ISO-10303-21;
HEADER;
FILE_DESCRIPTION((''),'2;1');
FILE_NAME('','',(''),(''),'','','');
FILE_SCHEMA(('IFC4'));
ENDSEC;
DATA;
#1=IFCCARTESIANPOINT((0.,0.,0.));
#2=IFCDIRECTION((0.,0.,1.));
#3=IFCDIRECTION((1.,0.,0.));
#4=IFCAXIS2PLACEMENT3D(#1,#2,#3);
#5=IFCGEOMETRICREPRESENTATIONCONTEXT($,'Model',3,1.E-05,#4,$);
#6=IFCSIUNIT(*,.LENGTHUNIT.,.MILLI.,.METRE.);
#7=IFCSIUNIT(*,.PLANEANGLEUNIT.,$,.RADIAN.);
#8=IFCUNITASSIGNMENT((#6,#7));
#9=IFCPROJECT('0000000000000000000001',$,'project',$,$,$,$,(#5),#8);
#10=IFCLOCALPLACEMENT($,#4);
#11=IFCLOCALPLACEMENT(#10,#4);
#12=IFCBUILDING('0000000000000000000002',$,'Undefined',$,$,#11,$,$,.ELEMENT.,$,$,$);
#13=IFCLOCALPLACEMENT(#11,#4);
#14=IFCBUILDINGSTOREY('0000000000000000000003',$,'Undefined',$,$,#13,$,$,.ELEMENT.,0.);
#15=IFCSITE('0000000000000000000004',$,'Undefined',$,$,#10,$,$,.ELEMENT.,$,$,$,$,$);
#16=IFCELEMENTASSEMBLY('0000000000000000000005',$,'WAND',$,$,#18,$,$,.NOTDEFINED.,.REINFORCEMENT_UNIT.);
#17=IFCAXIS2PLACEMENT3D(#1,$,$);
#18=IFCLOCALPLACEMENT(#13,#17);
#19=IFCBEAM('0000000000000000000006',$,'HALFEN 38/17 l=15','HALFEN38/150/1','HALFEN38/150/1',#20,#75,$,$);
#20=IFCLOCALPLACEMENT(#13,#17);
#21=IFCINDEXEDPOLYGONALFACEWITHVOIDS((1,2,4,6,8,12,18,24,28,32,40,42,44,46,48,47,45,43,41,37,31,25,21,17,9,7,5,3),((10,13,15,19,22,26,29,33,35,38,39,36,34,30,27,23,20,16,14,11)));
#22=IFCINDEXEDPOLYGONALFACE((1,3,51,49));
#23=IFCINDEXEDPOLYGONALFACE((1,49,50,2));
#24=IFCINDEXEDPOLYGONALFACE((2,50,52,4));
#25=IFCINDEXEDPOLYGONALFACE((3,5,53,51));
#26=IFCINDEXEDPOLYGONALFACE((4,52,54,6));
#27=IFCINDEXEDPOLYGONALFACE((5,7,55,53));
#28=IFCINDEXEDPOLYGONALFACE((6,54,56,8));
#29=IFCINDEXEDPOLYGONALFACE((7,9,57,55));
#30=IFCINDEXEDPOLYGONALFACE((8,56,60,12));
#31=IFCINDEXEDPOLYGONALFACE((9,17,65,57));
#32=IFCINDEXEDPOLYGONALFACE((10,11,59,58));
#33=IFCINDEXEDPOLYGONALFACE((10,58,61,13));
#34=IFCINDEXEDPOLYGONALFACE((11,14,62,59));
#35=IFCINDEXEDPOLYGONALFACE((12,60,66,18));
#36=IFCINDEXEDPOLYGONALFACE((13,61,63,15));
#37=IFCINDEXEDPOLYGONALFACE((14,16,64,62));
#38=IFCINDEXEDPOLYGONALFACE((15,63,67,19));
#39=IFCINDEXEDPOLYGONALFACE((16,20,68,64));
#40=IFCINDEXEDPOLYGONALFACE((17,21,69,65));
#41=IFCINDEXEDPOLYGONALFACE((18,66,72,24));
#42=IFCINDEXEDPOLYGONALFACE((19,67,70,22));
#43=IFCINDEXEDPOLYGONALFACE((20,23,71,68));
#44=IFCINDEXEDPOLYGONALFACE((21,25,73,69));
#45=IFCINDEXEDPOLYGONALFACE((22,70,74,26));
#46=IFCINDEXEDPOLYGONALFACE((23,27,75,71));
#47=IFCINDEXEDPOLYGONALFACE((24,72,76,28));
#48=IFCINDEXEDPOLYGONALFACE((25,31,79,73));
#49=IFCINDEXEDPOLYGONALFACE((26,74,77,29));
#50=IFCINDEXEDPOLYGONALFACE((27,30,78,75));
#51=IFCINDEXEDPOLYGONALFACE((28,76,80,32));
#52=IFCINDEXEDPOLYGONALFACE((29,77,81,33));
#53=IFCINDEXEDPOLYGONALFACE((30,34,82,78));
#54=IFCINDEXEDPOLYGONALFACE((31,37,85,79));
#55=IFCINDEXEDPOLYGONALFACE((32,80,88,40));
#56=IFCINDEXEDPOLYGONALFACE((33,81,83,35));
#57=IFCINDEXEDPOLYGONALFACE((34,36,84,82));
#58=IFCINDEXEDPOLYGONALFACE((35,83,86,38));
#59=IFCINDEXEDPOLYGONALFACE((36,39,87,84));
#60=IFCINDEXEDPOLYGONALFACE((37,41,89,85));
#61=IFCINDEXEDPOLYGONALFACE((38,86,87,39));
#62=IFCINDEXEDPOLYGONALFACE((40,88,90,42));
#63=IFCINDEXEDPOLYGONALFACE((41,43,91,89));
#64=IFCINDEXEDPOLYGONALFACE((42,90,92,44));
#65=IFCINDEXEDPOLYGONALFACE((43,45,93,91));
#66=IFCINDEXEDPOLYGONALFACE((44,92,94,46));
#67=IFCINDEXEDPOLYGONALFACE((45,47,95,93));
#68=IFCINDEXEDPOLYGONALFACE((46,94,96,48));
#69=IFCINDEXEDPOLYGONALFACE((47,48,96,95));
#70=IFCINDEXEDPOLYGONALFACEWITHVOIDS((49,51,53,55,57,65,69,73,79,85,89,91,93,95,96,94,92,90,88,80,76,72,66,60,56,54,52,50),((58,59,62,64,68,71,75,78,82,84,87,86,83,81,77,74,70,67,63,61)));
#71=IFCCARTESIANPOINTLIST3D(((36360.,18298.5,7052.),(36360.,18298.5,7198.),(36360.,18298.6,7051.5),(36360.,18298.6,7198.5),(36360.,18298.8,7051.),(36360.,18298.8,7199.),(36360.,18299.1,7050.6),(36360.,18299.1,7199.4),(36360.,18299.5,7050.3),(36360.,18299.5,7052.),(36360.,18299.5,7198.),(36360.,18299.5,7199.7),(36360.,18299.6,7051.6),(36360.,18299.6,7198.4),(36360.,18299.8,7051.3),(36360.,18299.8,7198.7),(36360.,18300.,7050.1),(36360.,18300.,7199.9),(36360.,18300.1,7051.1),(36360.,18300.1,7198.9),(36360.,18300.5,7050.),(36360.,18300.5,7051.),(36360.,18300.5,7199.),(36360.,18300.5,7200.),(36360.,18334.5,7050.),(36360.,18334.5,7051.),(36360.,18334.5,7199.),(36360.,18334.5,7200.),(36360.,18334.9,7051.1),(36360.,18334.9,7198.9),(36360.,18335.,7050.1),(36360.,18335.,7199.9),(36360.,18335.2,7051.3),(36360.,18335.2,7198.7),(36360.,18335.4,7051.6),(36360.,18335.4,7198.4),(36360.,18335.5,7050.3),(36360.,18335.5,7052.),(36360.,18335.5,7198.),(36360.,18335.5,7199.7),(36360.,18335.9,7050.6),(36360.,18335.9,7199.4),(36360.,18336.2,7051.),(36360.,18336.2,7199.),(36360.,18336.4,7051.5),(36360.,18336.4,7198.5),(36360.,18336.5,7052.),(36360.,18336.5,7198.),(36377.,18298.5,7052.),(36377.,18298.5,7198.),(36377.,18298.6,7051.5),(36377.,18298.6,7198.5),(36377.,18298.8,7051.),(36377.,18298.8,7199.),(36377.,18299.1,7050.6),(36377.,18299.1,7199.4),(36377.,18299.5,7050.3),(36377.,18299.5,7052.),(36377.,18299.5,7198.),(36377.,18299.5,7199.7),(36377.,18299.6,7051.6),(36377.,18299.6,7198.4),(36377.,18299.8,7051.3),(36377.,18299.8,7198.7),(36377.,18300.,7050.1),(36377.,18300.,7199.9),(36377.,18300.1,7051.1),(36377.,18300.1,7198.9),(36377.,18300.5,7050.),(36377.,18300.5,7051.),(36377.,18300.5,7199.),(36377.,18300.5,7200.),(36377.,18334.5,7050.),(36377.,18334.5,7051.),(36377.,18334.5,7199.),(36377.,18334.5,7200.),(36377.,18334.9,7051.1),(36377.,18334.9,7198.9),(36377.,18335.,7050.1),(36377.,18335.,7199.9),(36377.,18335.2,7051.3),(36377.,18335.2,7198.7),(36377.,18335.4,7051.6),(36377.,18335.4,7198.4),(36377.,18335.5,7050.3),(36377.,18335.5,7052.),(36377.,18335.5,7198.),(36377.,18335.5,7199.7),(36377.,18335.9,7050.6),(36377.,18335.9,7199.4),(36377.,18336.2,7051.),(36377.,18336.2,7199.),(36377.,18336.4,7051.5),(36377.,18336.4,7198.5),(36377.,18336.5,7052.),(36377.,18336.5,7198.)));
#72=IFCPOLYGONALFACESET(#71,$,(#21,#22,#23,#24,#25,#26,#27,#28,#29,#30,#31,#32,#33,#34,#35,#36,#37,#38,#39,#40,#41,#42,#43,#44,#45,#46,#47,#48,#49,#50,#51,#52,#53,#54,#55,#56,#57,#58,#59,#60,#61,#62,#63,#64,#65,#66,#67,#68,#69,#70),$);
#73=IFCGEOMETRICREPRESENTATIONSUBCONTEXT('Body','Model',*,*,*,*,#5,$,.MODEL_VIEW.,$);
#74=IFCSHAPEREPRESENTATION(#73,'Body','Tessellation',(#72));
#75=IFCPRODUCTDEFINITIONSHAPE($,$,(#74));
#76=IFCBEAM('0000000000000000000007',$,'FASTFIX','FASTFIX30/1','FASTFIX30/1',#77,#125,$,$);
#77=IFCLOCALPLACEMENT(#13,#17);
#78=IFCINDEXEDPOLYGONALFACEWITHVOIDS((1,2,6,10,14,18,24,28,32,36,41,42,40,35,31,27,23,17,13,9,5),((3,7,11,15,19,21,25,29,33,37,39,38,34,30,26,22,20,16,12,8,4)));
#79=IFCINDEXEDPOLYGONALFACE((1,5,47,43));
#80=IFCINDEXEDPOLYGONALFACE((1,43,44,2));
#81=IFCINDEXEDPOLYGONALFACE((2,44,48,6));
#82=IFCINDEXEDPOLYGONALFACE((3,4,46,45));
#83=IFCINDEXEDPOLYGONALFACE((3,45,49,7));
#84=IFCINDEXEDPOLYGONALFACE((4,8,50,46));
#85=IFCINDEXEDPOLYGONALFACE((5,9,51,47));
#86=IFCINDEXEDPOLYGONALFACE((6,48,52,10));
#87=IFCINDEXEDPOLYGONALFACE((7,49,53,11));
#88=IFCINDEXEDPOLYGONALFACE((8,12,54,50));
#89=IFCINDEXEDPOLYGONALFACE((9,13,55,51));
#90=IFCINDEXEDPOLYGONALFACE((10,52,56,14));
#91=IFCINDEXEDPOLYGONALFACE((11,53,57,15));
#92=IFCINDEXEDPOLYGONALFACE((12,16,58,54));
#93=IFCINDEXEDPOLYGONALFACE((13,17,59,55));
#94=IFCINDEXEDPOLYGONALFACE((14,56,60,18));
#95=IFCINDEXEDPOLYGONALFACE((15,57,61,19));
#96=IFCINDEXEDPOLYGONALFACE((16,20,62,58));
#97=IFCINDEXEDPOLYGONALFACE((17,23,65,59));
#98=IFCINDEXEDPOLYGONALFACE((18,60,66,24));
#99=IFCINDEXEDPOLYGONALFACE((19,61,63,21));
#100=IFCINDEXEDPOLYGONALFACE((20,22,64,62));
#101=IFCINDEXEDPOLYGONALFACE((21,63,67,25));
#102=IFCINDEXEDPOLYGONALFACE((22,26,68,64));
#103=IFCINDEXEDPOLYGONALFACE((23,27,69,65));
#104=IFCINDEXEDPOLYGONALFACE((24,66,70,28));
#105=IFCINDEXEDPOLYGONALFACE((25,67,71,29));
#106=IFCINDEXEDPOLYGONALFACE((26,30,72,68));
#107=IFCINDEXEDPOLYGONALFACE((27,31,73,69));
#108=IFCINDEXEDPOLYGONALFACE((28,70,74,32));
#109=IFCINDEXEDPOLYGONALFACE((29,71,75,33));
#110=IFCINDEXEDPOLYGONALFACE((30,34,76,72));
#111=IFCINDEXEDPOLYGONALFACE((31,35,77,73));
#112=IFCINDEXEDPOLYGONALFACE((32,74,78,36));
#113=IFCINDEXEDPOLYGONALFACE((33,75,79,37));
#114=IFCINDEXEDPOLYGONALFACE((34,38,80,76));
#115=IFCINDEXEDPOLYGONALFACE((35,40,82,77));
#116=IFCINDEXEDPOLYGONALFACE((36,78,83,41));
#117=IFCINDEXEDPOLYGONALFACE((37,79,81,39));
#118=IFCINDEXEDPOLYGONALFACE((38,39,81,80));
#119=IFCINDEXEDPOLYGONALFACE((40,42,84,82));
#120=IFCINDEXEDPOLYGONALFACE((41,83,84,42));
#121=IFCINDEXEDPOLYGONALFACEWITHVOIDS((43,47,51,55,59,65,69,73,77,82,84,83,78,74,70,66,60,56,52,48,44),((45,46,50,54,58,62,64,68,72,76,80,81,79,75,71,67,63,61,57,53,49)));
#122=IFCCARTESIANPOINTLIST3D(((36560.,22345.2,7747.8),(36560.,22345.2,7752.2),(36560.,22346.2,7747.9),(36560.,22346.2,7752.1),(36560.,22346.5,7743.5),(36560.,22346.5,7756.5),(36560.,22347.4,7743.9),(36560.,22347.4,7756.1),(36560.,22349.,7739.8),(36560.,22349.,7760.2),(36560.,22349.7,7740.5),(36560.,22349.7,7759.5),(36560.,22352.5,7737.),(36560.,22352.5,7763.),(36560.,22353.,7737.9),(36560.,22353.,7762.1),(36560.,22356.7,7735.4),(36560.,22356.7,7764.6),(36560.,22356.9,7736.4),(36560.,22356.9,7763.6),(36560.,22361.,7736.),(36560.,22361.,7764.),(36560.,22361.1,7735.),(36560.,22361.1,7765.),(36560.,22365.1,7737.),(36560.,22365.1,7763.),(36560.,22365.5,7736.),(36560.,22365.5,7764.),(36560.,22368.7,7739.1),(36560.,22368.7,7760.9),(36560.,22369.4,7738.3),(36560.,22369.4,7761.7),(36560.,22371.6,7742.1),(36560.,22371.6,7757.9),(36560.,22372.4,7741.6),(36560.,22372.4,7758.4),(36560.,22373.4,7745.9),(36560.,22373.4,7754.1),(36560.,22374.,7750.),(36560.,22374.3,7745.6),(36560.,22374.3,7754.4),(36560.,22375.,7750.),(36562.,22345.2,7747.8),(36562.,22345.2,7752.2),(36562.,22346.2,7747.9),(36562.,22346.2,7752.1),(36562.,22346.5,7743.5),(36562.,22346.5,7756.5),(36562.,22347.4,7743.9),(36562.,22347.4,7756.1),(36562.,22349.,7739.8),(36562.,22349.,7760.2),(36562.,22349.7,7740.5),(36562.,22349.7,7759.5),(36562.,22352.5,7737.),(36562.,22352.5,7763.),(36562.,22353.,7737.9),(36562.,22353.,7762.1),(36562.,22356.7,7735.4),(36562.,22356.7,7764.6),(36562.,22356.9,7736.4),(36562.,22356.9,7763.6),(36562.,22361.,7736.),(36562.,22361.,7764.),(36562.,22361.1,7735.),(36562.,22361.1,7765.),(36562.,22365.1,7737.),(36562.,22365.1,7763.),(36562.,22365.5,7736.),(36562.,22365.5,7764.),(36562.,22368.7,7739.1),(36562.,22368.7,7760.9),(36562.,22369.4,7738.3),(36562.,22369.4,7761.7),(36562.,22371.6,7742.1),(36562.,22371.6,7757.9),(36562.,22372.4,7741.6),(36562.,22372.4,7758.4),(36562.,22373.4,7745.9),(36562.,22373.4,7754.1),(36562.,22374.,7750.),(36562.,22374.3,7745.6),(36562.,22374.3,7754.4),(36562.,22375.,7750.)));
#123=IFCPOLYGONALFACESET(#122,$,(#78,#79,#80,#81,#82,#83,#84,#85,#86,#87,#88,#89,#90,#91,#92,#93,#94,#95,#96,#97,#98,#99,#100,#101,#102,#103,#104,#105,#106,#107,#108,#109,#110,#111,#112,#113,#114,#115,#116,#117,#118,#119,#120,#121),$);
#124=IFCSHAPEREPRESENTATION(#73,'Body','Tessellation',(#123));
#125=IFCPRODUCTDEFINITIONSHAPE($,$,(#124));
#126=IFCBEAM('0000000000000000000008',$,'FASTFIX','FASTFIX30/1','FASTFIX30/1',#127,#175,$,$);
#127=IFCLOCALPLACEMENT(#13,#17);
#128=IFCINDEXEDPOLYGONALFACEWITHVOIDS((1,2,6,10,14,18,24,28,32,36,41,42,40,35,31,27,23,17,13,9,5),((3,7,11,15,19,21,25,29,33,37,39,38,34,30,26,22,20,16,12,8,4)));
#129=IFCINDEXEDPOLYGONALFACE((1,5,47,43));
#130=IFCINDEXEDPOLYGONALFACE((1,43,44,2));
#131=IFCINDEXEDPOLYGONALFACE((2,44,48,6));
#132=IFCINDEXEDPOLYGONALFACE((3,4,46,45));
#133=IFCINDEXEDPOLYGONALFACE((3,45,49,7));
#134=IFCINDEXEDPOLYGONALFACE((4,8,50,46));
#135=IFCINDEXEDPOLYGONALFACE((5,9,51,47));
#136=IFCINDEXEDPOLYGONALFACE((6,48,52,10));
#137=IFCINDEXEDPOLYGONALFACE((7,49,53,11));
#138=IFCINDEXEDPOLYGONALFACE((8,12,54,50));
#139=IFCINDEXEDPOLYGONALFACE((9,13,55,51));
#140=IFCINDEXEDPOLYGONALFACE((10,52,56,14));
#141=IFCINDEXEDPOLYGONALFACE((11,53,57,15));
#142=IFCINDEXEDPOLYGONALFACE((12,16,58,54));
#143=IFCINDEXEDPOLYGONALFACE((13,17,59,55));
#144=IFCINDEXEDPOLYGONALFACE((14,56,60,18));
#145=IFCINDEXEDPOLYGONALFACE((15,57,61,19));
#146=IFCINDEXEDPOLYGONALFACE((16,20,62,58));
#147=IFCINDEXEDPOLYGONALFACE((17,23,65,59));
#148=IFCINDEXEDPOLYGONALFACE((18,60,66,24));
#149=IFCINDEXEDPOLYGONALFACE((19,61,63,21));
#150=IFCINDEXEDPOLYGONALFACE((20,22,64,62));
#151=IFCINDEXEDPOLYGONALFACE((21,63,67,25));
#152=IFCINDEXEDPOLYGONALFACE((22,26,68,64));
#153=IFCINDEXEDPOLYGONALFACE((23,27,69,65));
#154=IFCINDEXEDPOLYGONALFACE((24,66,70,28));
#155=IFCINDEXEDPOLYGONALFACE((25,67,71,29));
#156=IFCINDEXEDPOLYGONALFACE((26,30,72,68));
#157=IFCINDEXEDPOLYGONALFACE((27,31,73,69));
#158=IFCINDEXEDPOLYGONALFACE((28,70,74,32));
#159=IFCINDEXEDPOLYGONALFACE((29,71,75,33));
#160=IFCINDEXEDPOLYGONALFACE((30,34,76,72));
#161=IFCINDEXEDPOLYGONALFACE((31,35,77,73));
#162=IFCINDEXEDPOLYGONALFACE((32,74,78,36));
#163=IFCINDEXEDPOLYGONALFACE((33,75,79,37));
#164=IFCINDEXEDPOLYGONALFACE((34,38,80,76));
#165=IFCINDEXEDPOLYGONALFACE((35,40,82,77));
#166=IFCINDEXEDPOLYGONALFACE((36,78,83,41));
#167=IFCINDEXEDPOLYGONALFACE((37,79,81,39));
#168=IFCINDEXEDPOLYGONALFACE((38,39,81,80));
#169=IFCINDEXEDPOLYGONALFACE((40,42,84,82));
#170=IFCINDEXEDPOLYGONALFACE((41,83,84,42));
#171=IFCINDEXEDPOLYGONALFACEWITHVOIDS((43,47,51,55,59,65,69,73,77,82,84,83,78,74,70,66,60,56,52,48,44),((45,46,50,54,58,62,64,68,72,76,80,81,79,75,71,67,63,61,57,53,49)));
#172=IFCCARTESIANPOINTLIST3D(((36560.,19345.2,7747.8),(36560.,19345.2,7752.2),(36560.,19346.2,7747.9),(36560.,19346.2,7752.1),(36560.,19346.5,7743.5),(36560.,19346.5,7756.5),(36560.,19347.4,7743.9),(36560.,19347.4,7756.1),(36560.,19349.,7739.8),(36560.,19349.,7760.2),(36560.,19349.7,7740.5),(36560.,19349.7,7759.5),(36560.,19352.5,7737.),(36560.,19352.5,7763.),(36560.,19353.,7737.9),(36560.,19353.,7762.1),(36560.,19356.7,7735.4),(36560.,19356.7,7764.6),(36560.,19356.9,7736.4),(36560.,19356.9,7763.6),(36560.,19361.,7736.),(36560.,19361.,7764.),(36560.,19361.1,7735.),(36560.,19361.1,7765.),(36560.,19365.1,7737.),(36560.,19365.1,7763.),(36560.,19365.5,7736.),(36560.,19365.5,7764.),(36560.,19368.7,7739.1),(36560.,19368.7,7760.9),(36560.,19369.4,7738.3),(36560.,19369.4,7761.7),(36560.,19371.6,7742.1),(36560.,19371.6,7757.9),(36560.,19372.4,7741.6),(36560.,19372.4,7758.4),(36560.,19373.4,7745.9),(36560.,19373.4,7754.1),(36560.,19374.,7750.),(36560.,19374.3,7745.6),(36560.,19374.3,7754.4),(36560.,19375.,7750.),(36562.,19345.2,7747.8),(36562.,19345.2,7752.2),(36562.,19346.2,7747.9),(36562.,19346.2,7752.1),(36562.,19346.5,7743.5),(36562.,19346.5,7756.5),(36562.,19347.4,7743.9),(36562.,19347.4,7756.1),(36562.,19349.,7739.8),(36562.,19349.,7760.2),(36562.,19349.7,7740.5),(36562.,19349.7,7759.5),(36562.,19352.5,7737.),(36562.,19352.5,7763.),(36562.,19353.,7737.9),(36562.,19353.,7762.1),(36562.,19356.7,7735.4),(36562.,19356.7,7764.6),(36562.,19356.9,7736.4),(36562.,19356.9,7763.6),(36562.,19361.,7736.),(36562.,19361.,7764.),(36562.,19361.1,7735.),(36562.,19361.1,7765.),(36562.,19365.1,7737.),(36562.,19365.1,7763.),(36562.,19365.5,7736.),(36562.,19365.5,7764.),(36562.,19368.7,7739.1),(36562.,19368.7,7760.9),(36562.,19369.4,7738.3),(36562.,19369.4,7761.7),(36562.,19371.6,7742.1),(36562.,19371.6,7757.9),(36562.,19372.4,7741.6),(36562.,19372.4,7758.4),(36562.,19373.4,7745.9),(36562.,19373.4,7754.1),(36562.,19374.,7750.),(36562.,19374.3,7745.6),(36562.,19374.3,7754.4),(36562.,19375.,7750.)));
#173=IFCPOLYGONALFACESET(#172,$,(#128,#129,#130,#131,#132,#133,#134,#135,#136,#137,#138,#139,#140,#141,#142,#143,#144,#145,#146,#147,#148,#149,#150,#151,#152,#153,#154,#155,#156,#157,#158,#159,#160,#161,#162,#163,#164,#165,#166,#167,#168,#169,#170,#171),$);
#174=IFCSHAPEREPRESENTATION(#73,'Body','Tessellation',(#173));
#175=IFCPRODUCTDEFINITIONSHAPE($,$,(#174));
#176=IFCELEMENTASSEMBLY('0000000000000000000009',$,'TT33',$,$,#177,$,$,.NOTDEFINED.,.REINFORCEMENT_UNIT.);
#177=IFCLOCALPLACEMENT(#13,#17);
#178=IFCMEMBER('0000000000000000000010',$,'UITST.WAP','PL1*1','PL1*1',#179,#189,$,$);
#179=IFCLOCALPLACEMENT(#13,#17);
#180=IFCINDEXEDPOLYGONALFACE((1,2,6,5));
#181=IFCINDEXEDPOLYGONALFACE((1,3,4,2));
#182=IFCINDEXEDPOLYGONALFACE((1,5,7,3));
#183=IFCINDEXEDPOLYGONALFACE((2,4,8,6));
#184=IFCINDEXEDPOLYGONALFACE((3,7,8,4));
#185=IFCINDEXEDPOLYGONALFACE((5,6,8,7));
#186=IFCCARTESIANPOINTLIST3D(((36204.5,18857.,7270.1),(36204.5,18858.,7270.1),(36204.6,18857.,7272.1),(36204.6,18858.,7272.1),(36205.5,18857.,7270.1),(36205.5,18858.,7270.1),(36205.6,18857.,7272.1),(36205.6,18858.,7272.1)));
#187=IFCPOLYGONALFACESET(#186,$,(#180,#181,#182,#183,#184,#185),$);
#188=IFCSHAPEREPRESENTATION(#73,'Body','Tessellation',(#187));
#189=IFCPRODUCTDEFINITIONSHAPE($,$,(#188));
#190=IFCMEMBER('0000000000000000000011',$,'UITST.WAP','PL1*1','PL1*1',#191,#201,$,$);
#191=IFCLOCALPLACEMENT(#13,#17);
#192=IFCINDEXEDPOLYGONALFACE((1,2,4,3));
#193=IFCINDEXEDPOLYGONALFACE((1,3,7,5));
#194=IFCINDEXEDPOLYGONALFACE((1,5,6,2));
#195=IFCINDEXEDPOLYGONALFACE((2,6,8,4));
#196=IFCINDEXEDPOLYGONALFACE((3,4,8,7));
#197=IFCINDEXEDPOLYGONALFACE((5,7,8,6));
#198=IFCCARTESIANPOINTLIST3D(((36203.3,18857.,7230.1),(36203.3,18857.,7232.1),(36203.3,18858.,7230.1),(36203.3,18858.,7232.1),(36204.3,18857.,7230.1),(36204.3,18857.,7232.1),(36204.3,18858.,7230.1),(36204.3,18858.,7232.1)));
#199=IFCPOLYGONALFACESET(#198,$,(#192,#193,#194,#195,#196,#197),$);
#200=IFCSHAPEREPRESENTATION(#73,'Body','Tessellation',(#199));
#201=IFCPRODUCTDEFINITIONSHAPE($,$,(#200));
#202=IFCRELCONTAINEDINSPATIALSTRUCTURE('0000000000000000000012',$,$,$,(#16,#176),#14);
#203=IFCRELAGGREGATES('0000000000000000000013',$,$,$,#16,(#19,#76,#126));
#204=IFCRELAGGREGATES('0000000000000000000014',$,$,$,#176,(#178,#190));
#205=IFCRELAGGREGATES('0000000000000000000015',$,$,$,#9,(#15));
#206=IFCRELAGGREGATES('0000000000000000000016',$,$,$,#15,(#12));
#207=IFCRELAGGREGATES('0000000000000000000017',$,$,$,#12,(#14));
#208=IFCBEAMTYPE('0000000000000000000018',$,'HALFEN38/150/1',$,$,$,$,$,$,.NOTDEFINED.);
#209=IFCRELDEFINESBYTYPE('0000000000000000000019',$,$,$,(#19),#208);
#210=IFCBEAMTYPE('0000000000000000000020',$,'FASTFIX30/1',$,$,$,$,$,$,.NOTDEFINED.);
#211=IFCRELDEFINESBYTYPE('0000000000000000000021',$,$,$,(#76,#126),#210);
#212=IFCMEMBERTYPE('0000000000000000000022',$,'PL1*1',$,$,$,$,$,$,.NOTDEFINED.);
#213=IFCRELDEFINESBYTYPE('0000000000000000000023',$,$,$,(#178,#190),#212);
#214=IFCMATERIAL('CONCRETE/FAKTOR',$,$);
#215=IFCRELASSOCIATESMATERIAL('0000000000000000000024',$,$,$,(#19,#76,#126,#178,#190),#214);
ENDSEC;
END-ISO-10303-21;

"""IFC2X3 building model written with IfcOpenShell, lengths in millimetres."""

from ifc_helpers import new_model, si_unit, frame, frame_2d, origin_with_axes, place, context, subcontext, project, spatial, rectangle, hollow_rectangle, hollow_circle, extrude, material, type_object, element, aggregate, save


model = new_model("IFC2X3")

# Units and contexts
model_context = context("Model", 3, precision=1e-05, world=origin_with_axes())
body_context = subcontext(model_context, "Body", "Model", "MODEL_VIEW")
ifc_project = project(units=[si_unit("LENGTHUNIT", "METRE", prefix="MILLI"), si_unit("PLANEANGLEUNIT", "RADIAN")], contexts=[model_context])

# Site, building, storey
site_placement = place(None, origin_with_axes())
site = spatial("IfcSite", under=ifc_project, at=site_placement, Name="Undefined", CompositionType="ELEMENT")
building_placement = place(site_placement, origin_with_axes())
building = spatial("IfcBuilding", under=site, at=building_placement, Name="Undefined", CompositionType="ELEMENT")
storey_placement = place(building_placement, origin_with_axes())
storey = spatial("IfcBuildingStorey", under=building, at=storey_placement, Name="Undefined", CompositionType="ELEMENT", Elevation=0.0)

# Shared definitions
ifc_material_1 = material(Name="CONCRETE/FAKTOR")

# Element assembly
assembly_1_placement = place(storey_placement, origin_with_axes())
assembly_1 = element("IfcElementAssembly", 1, at=assembly_1_placement, inside=storey, Name="WAND", AssemblyPlace="NOTDEFINED", PredefinedType="REINFORCEMENT_UNIT")

# Beams
beam_type_1 = type_object("IfcBeamType", Name="HALFEN38/150/1", PredefinedType="NOTDEFINED")
beam_1_placement = place(assembly_1_placement, frame((36360.0, 18317.5, 7125.0), z_axis=(0.0, -1.0, 0.0), x_axis=(1.0, 0.0, 0.0)))
beam_1 = element("IfcBeam", 2, at=beam_1_placement, type_object=beam_type_1, material=ifc_material_1, Name="HALFEN 38/17 l=15", Description="HALFEN38/150/1", ObjectType="HALFEN38/150/1", context=body_context, shape_type="SweptSolid", body=[
    extrude(hollow_rectangle(XDim=150.0, YDim=38.0, WallThickness=1.0, InnerFilletRadius=1.0, OuterFilletRadius=2.0, at=frame_2d((0.0, 0.0), x_axis=(1.0, 0.0))), frame((17.0, 0.0, 0.0), z_axis=(-1.0, 0.0, 0.0), x_axis=(0.0, -1.0, 0.0)), (0.0, 0.0, 1.0), 17.0),
])
beam_type_2 = type_object("IfcBeamType", Name="FASTFIX30/1", PredefinedType="NOTDEFINED")
beam_2_placement = place(assembly_1_placement, frame((36560.0, 22360.0, 7750.0), z_axis=(0.0, 0.0, -1.0), x_axis=(1.0, 0.0, 0.0)))
beam_2 = element("IfcBeam", 3, at=beam_2_placement, type_object=beam_type_2, material=ifc_material_1, Name="FASTFIX", Description="FASTFIX30/1", ObjectType="FASTFIX30/1", context=body_context, shape_type="SweptSolid", body=[
    extrude(hollow_circle(Radius=15.0, WallThickness=1.0, at=frame_2d((0.0, 0.0), x_axis=(1.0, 0.0))), frame((2.0, 0.0, 0.0), z_axis=(-1.0, 0.0, 0.0), x_axis=(0.0, -1.0, 0.0)), (0.0, 0.0, 1.0), 2.0),
])
beam_3_placement = place(assembly_1_placement, frame((36560.0, 19360.0, 7750.0), z_axis=(0.0, 0.0, -1.0), x_axis=(1.0, 0.0, 0.0)))
beam_3 = element("IfcBeam", 4, at=beam_3_placement, type_object=beam_type_2, material=ifc_material_1, Name="FASTFIX", Description="FASTFIX30/1", ObjectType="FASTFIX30/1", context=body_context, shape_type="SweptSolid", body=[
    extrude(hollow_circle(Radius=15.0, WallThickness=1.0, at=frame_2d((0.0, 0.0), x_axis=(1.0, 0.0))), frame((2.0, 0.0, 0.0), z_axis=(-1.0, 0.0, 0.0), x_axis=(0.0, -1.0, 0.0)), (0.0, 0.0, 1.0), 2.0),
])
aggregate(assembly_1, [beam_1, beam_2, beam_3])

# Element assembly, members
assembly_2_placement = place(storey_placement, origin_with_axes())
assembly_2 = element("IfcElementAssembly", 5, at=assembly_2_placement, inside=storey, Name="TT33", AssemblyPlace="NOTDEFINED", PredefinedType="REINFORCEMENT_UNIT")
member_type = type_object("IfcMemberType", Name="PL1*1", PredefinedType="NOTDEFINED")
member_1_placement = place(assembly_2_placement, frame((36205.0, 18857.5, 7270.1), z_axis=(0.0, -1.0, 0.0), x_axis=(0.031107, 0.0, 0.999516)))
member_1 = element("IfcMember", 6, at=member_1_placement, type_object=member_type, material=ifc_material_1, Name="UITST.WAP", Description="PL1*1", ObjectType="PL1*1", context=body_context, shape_type="SweptSolid", body=[
    extrude(rectangle(XDim=1.0, YDim=1.0, at=frame_2d((0.0, 0.0), x_axis=(1.0, 0.0))), frame((2.0, 0.0, 0.0), z_axis=(-1.0, 0.0, 0.0), x_axis=(0.0, -1.0, 0.0)), (0.0, 0.0, 1.0), 2.0),
])
member_2_placement = place(assembly_2_placement, frame((36203.8, 18857.5, 7230.1), z_axis=(0.0, -1.0, 0.0), x_axis=(0.031107, 0.0, 0.999516)))
member_2 = element("IfcMember", 7, at=member_2_placement, type_object=member_type, material=ifc_material_1, Name="UITST.WAP", Description="PL1*1", ObjectType="PL1*1", context=body_context, shape_type="SweptSolid", body=[
    extrude(rectangle(XDim=1.0, YDim=1.0, at=frame_2d((0.0, 0.0), x_axis=(1.0, 0.0))), frame((2.0, 0.0, 0.0), z_axis=(-1.0, 0.0, 0.0), x_axis=(0.0, -1.0, 0.0)), (0.0, 0.0, 1.0), 2.0),
])
aggregate(assembly_2, [member_1, member_2])

save(model, "model.ifc")
